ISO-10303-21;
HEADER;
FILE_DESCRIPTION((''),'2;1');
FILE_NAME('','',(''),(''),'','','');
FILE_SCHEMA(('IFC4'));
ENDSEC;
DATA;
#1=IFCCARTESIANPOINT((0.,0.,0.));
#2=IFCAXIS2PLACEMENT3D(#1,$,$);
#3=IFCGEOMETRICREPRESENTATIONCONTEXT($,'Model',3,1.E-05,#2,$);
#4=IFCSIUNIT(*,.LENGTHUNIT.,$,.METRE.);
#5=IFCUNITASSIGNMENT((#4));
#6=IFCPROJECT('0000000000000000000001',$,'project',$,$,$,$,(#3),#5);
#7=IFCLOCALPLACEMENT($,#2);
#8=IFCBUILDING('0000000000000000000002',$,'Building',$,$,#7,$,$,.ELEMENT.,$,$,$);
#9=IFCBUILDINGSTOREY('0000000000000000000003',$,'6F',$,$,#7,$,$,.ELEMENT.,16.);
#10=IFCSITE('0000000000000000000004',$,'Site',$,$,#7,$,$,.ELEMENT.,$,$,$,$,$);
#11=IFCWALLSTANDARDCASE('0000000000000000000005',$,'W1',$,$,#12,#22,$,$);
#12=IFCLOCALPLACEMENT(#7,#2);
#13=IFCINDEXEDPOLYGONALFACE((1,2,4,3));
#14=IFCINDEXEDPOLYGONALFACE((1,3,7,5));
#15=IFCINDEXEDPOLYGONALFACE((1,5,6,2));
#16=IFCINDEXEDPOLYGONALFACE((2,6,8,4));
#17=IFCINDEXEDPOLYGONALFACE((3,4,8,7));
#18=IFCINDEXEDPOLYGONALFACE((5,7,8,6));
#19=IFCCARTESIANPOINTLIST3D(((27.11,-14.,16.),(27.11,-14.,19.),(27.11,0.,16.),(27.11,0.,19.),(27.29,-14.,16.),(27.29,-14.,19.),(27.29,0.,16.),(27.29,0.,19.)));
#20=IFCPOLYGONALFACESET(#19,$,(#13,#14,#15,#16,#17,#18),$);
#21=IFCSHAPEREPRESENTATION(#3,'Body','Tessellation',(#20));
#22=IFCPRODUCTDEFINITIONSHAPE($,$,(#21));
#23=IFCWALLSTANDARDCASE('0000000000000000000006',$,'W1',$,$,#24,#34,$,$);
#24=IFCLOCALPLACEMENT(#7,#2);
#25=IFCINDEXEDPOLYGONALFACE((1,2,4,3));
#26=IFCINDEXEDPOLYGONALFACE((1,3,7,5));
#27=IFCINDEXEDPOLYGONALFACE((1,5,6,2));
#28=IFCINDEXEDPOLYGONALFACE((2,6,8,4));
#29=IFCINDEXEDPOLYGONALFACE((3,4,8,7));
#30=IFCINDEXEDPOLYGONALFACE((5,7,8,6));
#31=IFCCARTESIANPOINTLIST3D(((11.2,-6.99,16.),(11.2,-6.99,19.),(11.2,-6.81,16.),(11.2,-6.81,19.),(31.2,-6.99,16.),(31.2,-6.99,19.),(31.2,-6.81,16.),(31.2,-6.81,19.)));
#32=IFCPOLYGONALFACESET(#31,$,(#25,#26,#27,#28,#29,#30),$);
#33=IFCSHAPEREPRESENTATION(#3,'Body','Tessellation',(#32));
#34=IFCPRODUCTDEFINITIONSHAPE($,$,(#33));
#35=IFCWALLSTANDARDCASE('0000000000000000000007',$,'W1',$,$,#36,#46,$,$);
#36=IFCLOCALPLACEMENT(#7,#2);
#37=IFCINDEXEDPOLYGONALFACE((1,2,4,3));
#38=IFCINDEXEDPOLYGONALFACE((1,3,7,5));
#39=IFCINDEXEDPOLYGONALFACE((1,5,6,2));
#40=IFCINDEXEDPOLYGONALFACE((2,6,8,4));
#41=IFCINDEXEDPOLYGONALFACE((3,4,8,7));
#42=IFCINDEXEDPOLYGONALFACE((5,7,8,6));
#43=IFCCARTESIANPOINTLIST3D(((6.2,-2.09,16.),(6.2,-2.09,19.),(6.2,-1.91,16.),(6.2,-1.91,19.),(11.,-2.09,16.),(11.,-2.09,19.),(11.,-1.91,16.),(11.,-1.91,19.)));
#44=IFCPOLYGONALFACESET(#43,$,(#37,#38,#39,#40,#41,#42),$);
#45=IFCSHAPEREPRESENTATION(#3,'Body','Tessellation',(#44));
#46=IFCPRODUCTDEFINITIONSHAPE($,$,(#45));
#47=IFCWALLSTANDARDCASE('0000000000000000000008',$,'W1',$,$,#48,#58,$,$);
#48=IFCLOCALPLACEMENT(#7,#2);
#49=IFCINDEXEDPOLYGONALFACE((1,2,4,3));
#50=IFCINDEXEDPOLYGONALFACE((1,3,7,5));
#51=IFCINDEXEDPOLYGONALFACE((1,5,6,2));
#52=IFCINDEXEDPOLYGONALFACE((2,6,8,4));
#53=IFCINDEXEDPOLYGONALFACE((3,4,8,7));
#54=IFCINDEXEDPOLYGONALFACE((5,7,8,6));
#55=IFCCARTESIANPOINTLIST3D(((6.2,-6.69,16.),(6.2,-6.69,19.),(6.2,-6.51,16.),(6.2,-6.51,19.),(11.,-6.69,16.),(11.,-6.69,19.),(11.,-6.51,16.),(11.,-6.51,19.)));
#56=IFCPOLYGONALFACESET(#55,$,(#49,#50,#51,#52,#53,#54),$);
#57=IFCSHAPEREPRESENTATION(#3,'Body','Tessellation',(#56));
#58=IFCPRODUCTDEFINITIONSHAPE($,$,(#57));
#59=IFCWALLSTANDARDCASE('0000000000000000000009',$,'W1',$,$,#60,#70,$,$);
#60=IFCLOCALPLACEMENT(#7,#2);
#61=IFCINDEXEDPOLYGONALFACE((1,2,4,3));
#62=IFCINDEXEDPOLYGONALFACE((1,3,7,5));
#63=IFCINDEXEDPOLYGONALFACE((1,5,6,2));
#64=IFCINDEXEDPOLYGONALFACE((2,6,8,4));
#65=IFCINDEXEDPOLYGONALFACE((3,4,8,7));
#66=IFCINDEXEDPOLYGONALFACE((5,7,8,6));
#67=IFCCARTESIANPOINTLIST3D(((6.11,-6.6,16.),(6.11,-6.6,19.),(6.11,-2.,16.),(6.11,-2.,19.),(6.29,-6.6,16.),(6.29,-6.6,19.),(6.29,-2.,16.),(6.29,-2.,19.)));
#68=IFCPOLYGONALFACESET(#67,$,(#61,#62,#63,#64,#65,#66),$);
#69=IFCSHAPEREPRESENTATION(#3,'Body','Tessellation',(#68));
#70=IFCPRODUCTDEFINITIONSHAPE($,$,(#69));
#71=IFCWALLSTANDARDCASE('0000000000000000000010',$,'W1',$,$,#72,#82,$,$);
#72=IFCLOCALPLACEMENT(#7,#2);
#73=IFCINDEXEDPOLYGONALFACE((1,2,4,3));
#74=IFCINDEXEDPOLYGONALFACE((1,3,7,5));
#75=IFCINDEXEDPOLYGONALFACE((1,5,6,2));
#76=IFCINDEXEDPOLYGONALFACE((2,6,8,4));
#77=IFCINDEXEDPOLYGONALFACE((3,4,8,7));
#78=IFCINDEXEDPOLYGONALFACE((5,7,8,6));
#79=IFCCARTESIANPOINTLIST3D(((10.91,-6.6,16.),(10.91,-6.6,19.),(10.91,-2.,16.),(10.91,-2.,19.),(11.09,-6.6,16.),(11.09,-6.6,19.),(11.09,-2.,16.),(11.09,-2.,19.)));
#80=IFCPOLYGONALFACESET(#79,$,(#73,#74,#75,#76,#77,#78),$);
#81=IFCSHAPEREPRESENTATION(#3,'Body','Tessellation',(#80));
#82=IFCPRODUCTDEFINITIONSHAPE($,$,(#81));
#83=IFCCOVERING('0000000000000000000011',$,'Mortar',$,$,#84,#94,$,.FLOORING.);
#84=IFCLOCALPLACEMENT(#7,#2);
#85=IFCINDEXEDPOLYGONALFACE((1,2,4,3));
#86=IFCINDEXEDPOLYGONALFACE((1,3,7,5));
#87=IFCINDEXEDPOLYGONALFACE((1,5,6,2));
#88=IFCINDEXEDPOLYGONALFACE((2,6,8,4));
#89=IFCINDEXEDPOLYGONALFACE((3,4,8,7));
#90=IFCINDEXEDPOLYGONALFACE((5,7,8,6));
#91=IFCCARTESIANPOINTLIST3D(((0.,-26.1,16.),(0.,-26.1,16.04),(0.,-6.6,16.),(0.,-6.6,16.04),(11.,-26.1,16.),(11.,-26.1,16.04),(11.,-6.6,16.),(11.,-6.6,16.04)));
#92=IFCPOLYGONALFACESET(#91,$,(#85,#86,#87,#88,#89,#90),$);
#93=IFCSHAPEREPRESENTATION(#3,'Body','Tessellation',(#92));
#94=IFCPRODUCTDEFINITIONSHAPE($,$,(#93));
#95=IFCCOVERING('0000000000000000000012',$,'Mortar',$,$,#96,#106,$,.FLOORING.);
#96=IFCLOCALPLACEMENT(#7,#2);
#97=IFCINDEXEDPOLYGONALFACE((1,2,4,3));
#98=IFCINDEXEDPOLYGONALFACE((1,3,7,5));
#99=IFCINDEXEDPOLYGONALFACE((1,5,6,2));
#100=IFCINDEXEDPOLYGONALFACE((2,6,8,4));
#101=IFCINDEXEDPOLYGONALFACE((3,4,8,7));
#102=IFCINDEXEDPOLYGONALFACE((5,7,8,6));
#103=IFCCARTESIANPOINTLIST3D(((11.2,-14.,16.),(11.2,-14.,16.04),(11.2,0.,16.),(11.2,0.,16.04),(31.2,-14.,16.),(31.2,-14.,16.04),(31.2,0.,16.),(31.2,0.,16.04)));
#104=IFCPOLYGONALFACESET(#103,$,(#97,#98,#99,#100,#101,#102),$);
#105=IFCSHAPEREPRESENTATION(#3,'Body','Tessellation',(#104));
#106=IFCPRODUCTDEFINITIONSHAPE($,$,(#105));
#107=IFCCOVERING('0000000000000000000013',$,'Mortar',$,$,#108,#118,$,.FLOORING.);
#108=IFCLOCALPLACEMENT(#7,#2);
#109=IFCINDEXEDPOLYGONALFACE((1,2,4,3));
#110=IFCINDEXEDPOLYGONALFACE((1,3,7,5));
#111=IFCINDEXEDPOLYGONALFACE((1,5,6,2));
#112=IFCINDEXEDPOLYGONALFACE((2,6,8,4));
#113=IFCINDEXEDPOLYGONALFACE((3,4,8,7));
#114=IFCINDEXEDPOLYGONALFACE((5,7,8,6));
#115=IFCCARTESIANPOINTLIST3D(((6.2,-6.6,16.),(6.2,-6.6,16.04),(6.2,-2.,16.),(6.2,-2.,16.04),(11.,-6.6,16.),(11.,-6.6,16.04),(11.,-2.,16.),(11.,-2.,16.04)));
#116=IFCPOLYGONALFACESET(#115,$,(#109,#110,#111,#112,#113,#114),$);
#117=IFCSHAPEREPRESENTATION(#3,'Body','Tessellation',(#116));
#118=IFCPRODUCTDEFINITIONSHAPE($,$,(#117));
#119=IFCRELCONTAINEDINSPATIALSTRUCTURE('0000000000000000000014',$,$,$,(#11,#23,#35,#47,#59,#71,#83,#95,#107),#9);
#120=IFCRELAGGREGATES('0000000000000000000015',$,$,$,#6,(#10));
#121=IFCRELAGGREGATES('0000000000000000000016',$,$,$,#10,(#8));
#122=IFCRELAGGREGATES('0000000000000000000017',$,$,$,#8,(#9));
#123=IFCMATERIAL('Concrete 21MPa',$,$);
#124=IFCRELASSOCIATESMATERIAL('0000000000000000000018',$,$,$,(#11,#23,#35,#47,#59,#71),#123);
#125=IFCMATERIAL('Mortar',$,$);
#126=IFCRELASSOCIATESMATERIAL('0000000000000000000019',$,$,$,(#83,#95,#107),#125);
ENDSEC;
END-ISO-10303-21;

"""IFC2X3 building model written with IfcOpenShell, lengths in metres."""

from ifc_helpers import new_model, si_unit, frame, origin, origin_2d, place, context, project, spatial, rectangle, extrude, material, element, save


model = new_model("IFC2X3")

# Units and contexts
model_context = context("Model", 3, precision=1e-05, world=origin())
ifc_project = project(units=[si_unit("LENGTHUNIT", "METRE")], contexts=[model_context])

# Site, building, storey
placement = place(None, origin())
site = spatial("IfcSite", under=ifc_project, at=placement, Name="Site", CompositionType="ELEMENT")
building = spatial("IfcBuilding", under=site, at=placement, Name="Building", CompositionType="ELEMENT")
storey = spatial("IfcBuildingStorey", under=building, at=placement, Name="6F", CompositionType="ELEMENT", Elevation=16.0)

# Shared definitions
ifc_material_1 = material(Name="Concrete 21MPa")

# Walls
for number, where, name in (
    (1, (27.2, -7.0, 16.0), "W1"),
):
    element("IfcWallStandardCase", number, at=place(None, frame(where)), inside=storey, material=ifc_material_1, Name=name, context=model_context, shape_type="SweptSolid", body=[
        extrude(rectangle(XDim=0.18, YDim=14.0, at=origin_2d()), origin(), (0.0, 0.0, 1.0), 3.0),
    ])
wall_1_placement = place(None, frame((21.2, -6.9, 16.0)))
element("IfcWallStandardCase", 2, at=wall_1_placement, inside=storey, material=ifc_material_1, Name="W1", context=model_context, shape_type="SweptSolid", body=[
    extrude(rectangle(XDim=20.0, YDim=0.18, at=origin_2d()), origin(), (0.0, 0.0, 1.0), 3.0),
])
for number, where, name in (
    (3, (8.6, -2.0, 16.0), "W1"),
    (4, (8.6, -6.6, 16.0), "W1"),
):
    element("IfcWallStandardCase", number, at=place(None, frame(where)), inside=storey, material=ifc_material_1, Name=name, context=model_context, shape_type="SweptSolid", body=[
        extrude(rectangle(XDim=4.8, YDim=0.18, at=origin_2d()), origin(), (0.0, 0.0, 1.0), 3.0),
    ])
for number, where, name in (
    (5, (6.2, -4.3, 16.0), "W1"),
    (6, (11.0, -4.3, 16.0), "W1"),
):
    element("IfcWallStandardCase", number, at=place(None, frame(where)), inside=storey, material=ifc_material_1, Name=name, context=model_context, shape_type="SweptSolid", body=[
        extrude(rectangle(XDim=0.18, YDim=4.6, at=origin_2d()), origin(), (0.0, 0.0, 1.0), 3.0),
    ])

# Coverings
ifc_material_2 = material(Name="Mortar")
covering_1_placement = place(None, frame((5.5, -16.35, 16.0)))
element("IfcCovering", 7, at=covering_1_placement, inside=storey, material=ifc_material_2, Name="Mortar", PredefinedType="FLOORING", context=model_context, shape_type="SweptSolid", body=[
    extrude(rectangle(XDim=11.0, YDim=19.5, at=origin_2d()), origin(), (0.0, 0.0, 1.0), 0.04),
])
covering_2_placement = place(None, frame((21.2, -7.0, 16.0)))
element("IfcCovering", 8, at=covering_2_placement, inside=storey, material=ifc_material_2, Name="Mortar", PredefinedType="FLOORING", context=model_context, shape_type="SweptSolid", body=[
    extrude(rectangle(XDim=20.0, YDim=14.0, at=origin_2d()), origin(), (0.0, 0.0, 1.0), 0.04),
])
covering_3_placement = place(None, frame((8.6, -4.3, 16.0)))
element("IfcCovering", 9, at=covering_3_placement, inside=storey, material=ifc_material_2, Name="Mortar", PredefinedType="FLOORING", context=model_context, shape_type="SweptSolid", body=[
    extrude(rectangle(XDim=4.8, YDim=4.6, at=origin_2d()), origin(), (0.0, 0.0, 1.0), 0.04),
])

save(model, "model.ifc")
